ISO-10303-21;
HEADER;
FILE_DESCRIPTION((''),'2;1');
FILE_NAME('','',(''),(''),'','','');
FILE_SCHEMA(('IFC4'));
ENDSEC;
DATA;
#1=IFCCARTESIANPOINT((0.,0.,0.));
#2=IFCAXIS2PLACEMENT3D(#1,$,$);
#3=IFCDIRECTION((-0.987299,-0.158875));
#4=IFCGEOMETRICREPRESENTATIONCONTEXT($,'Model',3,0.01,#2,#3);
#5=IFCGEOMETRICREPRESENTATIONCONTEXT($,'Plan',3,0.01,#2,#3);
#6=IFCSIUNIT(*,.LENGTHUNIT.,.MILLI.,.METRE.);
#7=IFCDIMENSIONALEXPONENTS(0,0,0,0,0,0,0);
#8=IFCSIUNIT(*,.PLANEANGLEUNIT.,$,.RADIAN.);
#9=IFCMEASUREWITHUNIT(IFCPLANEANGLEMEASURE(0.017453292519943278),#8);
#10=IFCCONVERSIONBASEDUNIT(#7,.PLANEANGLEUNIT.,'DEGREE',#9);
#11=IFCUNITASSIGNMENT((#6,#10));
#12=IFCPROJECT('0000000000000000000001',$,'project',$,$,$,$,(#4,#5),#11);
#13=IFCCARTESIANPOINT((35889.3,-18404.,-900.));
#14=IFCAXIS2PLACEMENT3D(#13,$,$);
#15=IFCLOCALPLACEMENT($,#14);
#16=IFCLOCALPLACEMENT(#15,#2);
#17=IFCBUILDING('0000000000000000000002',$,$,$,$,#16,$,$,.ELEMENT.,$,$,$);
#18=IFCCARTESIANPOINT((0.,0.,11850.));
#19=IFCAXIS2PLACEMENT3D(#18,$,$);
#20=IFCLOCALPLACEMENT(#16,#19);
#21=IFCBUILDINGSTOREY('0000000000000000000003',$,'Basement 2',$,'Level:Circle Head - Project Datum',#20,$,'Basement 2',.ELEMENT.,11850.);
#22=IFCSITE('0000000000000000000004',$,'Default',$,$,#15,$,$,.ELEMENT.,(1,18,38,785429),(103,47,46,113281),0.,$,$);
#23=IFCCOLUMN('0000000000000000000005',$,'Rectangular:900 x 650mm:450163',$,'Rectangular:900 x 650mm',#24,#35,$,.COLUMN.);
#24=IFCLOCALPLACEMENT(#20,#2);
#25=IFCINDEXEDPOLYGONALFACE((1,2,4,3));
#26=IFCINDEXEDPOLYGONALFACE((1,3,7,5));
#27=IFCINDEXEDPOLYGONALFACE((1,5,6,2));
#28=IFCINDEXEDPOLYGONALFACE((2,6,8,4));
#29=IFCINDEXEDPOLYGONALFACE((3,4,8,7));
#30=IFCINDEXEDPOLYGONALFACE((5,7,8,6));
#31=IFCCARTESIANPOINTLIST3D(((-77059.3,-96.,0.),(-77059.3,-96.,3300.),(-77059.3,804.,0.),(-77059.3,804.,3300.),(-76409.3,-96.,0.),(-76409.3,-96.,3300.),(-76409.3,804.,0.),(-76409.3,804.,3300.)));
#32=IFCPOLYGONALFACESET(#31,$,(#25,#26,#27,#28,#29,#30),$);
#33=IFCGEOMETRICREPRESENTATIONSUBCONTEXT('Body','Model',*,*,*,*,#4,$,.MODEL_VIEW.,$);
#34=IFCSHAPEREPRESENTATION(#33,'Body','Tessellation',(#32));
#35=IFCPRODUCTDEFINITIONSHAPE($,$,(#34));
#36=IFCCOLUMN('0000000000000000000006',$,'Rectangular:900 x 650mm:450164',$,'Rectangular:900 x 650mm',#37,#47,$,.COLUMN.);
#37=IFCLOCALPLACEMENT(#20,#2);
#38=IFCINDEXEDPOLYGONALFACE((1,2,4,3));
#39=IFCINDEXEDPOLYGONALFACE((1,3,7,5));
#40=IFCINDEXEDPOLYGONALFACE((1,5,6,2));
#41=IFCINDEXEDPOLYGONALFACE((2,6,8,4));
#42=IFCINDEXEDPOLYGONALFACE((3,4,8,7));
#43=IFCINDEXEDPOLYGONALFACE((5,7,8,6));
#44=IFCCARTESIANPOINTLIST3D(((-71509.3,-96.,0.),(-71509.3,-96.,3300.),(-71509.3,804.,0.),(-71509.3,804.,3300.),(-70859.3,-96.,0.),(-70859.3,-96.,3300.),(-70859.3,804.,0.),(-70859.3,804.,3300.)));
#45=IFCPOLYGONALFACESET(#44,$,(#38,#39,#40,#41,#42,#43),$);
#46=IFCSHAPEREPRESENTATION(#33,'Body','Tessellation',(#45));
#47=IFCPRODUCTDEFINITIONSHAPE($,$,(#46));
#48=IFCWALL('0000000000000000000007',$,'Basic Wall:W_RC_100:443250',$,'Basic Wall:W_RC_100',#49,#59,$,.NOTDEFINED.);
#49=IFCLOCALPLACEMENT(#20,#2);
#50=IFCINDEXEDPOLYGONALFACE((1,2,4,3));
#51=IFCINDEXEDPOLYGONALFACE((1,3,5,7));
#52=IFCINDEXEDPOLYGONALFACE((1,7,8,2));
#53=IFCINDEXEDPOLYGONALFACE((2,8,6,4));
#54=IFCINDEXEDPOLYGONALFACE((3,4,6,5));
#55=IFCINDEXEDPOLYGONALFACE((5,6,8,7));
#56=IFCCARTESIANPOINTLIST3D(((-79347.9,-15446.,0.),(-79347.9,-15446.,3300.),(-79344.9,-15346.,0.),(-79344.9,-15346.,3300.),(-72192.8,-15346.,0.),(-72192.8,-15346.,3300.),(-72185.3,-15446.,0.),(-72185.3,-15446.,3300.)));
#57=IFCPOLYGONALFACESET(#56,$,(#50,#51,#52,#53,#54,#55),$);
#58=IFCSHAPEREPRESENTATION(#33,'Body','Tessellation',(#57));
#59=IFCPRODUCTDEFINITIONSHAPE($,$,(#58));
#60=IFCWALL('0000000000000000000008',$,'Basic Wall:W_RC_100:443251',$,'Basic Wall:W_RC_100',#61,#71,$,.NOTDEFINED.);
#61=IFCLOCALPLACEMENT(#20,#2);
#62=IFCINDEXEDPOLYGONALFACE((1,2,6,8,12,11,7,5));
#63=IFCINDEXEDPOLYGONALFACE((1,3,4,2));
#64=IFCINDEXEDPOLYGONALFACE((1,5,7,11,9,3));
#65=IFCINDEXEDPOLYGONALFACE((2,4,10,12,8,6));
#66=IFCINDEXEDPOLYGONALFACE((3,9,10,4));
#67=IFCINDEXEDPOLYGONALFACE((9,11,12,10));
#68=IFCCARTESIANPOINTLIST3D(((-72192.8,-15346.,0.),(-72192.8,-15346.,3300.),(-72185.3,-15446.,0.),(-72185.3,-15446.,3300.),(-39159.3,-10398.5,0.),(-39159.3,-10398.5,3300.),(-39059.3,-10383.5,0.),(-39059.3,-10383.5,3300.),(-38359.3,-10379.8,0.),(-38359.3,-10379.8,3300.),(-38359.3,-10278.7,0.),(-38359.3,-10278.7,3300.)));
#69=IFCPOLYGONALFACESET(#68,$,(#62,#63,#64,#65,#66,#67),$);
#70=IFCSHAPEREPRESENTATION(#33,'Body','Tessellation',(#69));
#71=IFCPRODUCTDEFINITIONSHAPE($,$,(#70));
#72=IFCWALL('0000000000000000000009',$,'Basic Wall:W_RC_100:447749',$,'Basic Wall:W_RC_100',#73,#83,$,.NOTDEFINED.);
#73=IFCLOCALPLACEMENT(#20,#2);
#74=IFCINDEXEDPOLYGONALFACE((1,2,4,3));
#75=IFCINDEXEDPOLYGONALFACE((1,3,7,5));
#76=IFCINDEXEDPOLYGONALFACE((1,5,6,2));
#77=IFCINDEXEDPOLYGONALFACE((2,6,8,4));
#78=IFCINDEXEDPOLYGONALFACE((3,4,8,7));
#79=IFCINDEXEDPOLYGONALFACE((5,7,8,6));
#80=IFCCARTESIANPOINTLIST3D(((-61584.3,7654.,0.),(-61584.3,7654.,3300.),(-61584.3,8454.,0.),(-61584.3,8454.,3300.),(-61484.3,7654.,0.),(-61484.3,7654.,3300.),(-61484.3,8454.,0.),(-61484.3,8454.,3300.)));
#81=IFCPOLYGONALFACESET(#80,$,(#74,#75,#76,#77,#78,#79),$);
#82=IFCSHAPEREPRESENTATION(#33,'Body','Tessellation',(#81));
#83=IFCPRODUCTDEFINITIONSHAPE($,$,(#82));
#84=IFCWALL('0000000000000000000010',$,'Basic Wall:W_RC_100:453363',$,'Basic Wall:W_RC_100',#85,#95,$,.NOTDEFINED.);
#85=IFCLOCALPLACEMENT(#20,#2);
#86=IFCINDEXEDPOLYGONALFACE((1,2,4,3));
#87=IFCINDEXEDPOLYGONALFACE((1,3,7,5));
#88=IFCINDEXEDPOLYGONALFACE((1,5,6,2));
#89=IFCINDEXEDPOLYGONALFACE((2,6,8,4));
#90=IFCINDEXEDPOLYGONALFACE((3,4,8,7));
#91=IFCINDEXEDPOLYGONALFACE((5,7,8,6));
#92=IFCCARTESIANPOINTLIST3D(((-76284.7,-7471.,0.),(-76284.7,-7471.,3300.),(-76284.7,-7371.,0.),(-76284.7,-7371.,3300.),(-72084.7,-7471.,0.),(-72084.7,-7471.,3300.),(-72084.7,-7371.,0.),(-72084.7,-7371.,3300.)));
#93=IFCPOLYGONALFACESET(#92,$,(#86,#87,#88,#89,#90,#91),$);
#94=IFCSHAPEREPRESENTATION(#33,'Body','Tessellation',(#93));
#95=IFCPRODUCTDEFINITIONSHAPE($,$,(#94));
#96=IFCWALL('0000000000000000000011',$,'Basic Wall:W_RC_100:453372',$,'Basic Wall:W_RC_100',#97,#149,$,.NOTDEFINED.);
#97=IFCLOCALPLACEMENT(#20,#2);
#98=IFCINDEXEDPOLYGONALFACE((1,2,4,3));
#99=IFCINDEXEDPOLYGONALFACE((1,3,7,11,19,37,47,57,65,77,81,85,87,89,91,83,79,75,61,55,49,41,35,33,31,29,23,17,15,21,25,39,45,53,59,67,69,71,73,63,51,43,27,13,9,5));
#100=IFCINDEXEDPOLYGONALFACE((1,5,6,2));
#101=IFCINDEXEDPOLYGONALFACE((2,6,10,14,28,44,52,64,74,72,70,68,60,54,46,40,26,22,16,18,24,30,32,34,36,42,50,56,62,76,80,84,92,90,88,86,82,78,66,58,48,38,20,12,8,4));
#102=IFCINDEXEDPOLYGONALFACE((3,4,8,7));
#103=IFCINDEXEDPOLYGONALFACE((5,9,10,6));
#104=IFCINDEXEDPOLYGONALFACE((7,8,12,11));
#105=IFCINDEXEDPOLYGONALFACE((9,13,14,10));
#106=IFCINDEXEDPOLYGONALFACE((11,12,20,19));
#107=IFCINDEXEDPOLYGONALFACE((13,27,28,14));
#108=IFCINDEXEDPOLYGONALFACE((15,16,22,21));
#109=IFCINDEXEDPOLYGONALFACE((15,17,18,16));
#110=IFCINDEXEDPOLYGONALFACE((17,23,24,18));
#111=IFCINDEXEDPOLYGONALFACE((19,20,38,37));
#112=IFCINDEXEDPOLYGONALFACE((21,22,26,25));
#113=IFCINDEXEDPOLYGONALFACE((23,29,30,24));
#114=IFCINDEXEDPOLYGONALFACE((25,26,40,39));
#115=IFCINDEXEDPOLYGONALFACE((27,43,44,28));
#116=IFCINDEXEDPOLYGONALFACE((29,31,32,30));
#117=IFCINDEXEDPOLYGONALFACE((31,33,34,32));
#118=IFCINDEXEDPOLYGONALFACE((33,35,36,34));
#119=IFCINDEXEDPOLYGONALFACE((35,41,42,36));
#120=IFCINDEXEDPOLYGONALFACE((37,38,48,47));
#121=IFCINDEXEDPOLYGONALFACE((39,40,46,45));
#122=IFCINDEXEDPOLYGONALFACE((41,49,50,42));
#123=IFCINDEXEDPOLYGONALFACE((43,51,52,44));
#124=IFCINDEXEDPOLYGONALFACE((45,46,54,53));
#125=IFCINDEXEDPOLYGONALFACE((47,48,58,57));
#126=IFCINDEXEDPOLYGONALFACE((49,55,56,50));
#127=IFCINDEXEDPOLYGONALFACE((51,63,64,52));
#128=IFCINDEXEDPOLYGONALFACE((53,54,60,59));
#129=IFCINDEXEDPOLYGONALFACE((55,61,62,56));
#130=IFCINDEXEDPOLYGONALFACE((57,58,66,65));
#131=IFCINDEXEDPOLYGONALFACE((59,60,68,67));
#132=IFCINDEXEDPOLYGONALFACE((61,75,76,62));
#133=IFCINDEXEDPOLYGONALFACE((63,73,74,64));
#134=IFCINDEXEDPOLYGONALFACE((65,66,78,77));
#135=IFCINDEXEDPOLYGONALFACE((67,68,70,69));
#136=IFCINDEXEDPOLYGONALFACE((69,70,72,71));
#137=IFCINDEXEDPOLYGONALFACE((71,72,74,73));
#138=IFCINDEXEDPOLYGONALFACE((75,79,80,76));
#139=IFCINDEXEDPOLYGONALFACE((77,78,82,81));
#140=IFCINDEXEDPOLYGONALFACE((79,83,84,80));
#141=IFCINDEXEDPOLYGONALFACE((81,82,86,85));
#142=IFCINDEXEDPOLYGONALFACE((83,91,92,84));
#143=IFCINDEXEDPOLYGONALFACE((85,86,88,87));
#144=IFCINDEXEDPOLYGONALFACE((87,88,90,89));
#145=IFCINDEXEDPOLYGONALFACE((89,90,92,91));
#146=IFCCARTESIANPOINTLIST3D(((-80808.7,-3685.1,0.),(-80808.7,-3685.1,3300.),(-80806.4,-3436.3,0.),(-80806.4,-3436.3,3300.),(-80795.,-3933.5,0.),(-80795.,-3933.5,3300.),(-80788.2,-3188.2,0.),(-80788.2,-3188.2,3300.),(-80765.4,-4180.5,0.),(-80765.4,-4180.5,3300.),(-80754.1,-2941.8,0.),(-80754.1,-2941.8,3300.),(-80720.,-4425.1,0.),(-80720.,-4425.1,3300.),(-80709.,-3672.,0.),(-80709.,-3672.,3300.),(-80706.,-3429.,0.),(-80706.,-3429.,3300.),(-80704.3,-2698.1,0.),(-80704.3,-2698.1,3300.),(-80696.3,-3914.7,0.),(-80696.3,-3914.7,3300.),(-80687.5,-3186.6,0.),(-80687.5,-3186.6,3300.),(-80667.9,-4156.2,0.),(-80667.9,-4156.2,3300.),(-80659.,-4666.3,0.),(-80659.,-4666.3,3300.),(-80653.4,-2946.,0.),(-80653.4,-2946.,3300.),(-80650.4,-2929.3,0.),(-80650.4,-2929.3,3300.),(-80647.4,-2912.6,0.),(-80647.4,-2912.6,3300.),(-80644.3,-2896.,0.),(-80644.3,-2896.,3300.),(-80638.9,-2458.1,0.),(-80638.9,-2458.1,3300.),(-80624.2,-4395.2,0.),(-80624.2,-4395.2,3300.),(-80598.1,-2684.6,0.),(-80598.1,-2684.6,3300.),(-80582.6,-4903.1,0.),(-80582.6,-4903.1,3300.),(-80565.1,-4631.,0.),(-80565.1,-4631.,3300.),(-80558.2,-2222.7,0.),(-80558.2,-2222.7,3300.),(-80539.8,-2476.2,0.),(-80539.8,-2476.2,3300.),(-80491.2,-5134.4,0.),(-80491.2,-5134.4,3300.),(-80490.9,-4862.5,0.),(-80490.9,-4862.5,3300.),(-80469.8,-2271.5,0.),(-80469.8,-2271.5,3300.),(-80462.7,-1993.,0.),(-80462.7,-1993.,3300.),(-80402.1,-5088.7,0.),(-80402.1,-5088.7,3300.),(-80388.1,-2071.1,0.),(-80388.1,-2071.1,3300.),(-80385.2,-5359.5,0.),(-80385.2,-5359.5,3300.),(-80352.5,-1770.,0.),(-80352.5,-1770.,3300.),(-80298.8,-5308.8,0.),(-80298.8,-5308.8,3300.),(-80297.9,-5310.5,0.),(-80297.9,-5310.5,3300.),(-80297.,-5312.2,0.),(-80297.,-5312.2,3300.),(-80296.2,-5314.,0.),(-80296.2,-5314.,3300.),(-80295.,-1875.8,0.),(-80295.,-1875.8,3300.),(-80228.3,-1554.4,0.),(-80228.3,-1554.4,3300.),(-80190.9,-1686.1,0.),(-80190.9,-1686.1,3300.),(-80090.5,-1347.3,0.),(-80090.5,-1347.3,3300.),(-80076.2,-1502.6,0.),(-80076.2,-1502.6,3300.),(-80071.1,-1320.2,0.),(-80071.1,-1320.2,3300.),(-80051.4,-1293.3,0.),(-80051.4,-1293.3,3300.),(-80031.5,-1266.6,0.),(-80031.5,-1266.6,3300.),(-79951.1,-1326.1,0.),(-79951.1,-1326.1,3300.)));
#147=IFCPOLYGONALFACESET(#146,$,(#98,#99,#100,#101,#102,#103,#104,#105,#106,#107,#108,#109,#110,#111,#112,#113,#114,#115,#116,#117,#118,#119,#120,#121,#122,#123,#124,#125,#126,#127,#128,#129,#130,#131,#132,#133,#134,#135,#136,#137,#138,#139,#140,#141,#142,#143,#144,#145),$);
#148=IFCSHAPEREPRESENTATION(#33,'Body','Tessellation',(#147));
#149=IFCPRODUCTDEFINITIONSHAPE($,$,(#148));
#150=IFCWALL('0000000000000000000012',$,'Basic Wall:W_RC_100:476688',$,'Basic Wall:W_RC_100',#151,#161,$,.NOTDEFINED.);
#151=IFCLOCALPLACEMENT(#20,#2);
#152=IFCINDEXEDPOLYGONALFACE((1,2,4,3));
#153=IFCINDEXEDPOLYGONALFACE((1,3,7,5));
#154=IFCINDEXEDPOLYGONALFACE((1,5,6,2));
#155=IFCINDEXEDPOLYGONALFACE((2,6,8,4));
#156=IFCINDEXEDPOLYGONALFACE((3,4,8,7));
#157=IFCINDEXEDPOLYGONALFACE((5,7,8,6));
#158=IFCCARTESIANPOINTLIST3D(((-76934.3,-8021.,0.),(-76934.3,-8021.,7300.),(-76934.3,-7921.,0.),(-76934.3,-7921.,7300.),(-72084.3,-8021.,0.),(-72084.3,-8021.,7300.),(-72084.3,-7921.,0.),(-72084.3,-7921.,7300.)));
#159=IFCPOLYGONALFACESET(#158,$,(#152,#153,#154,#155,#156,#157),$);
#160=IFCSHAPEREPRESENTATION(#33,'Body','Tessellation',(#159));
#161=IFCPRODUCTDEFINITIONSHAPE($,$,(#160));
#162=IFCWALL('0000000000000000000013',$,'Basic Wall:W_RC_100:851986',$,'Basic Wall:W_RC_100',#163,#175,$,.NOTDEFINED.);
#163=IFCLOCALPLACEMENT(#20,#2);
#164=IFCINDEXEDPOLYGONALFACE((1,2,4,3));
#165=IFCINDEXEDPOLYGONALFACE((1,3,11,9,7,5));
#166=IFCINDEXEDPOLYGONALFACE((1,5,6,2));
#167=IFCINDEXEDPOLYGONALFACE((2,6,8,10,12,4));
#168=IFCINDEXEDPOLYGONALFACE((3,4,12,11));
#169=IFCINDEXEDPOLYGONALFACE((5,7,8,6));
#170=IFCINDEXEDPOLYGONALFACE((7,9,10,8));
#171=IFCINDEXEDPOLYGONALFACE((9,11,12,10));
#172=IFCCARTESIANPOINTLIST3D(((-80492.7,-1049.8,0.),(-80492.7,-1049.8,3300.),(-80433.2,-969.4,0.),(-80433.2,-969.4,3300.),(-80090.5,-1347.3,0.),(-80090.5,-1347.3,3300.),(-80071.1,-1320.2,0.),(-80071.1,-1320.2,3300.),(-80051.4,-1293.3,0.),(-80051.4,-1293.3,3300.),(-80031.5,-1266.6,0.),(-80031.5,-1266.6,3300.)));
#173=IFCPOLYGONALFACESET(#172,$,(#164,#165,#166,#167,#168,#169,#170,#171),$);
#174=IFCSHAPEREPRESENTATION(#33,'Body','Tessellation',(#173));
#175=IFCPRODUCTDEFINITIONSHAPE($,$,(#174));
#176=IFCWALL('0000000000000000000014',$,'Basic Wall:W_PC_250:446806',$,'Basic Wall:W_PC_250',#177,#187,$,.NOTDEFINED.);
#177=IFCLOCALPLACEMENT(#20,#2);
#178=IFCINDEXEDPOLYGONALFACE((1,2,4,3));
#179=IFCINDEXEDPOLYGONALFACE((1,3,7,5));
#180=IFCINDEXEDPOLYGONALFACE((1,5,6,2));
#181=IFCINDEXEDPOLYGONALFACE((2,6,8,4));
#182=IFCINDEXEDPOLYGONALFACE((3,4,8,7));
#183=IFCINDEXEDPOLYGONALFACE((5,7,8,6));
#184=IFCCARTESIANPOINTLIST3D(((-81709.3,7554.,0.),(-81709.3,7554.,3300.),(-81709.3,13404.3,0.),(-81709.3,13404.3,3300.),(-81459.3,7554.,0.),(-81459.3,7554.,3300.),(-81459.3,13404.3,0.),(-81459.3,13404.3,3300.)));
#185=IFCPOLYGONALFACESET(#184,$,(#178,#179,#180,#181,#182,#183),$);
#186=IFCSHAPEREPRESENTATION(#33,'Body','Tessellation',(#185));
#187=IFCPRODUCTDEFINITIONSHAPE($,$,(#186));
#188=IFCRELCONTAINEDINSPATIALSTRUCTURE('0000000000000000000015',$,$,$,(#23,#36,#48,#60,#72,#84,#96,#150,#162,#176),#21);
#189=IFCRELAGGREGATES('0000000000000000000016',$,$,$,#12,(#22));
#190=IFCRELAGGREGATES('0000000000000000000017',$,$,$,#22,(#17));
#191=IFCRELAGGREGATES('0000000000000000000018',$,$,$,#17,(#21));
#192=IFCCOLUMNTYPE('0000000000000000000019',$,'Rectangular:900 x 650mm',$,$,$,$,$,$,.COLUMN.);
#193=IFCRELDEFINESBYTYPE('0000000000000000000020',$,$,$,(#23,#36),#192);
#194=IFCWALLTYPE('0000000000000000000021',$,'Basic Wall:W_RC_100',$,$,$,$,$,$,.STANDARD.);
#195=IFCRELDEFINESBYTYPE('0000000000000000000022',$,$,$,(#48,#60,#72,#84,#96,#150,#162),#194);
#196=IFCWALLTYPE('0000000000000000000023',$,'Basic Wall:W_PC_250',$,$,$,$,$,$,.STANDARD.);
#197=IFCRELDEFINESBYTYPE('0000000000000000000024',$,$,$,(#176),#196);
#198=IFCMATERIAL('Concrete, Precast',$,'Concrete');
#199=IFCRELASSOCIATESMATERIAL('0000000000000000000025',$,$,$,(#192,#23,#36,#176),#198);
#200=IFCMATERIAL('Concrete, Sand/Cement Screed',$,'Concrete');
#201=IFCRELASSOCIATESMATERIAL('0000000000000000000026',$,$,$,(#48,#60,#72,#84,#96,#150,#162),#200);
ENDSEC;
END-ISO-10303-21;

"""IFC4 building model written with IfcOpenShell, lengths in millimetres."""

from ifc_helpers import new_model, entity, si_unit, converted_unit, direction, frame, origin, place, context, subcontext, project, spatial, line, arc, indexed_curve, outline, extrude, source, transform, mapped, material, type_object, type_shapes, element, save


model = new_model("IFC4")

# Units and contexts
model_context = context("Model", 3, precision=0.01, world=origin(), true_north=direction((-0.987299, -0.158875)))
plan_context = context("Plan", 3, precision=0.01, world=origin(), true_north=direction((-0.987299, -0.158875)))
body_context = subcontext(model_context, "Body", "Model", "MODEL_VIEW")
ifc_project = project(units=[si_unit("LENGTHUNIT", "METRE", prefix="MILLI"), converted_unit("PLANEANGLEUNIT", "DEGREE", entity("IfcPlaneAngleMeasure", 0.017453292519943278), si_unit("PLANEANGLEUNIT", "RADIAN"), dimensions=[0, 0, 0, 0, 0, 0, 0])], contexts=[model_context, plan_context])

# Site, building, storey
site_placement = place(None, frame((35889.3, -18404.0, -900.0)))
site = spatial("IfcSite", under=ifc_project, at=site_placement, Name="Default", CompositionType="ELEMENT", RefLatitude=(1, 18, 38, 785429), RefLongitude=(103, 47, 46, 113281), RefElevation=0.0)
building_placement = place(site_placement, origin())
building = spatial("IfcBuilding", under=site, at=building_placement, CompositionType="ELEMENT")
storey_placement = place(building_placement, frame((0.0, 0.0, 11850.0)))
storey = spatial("IfcBuildingStorey", under=building, at=storey_placement, Name="Basement 2", ObjectType="Level:Circle Head - Project Datum", LongName="Basement 2", CompositionType="ELEMENT", Elevation=11850.0)

# Columns
ifc_material_1 = material(Name="Concrete, Precast", Category="Concrete")
column_type = type_object("IfcColumnType", Name="Rectangular:900 x 650mm", PredefinedType="COLUMN", material=ifc_material_1)
shared_shape_1 = source(origin(), body_context, "Body", "SweptSolid", [
    extrude(outline(indexed_curve([(-325.0, -450.0), (325.0, -450.0), (325.0, 450.0), (-325.0, 450.0), (-325.0, -450.0)], self_intersect=False)), frame((0.0, 0.0, 11850.0), z_axis=(0.0, 0.0, 1.0), x_axis=(-1.0, 0.0, 0.0)), (0.0, 0.0, 1.0), 3300.0),
])
type_shapes(column_type, [shared_shape_1])
for number, where, name in (
    (1, (-76734.3, 354.0, -11850.0), "Rectangular:900 x 650mm:450163"),
    (2, (-71184.3, 354.0, -11850.0), "Rectangular:900 x 650mm:450164"),
):
    element("IfcColumn", number, at=place(storey_placement, frame(where)), inside=storey, type_object=column_type, material=ifc_material_1, Name=name, ObjectType="Rectangular:900 x 650mm", PredefinedType="COLUMN", context=body_context, shape_type="MappedRepresentation", body=[
        mapped(shared_shape_1, transform((0.0, 0.0, 0.0), scale=1.0)),
    ])

# Walls
ifc_material_2 = material(Name="Concrete, Sand/Cement Screed", Category="Concrete")
wall_type_1 = type_object("IfcWallType", Name="Basic Wall:W_RC_100", PredefinedType="STANDARD")
wall_1_placement = place(storey_placement, frame((-72185.3, -15396.0, 0.0), z_axis=(0.0, 0.0, 1.0), x_axis=(-1.0, 0.0, 0.0)))
element("IfcWall", 3, at=wall_1_placement, inside=storey, type_object=wall_type_1, material=ifc_material_2, Name="Basic Wall:W_RC_100:443250", ObjectType="Basic Wall:W_RC_100", PredefinedType="NOTDEFINED", context=body_context, shape_type="SweptSolid", body=[
    extrude(outline(indexed_curve([(7159.5, -50.0), (7162.6, 50.0), (0.0, 50.0), (7.4, -50.0), (7159.5, -50.0)], self_intersect=False)), origin(), (0.0, 0.0, 1.0), 3300.0),
])
wall_2_placement = place(storey_placement, frame((-72192.7, -15396.5, 0.0), z_axis=(0.0, 0.0, 1.0), x_axis=(0.988969, 0.148119, 0.0)))
element("IfcWall", 4, at=wall_2_placement, inside=storey, type_object=wall_type_1, material=ifc_material_2, Name="Basic Wall:W_RC_100:443251", ObjectType="Basic Wall:W_RC_100", PredefinedType="NOTDEFINED", context=body_context, shape_type="SweptSolid", body=[
    extrude(outline(indexed_curve([(34203.3, -50.0), (34218.2, 50.0), (33510.4, 50.0), (33409.3, 50.0), (7.4, 50.0), (0.0, -50.0), (34203.3, -50.0)], self_intersect=False)), origin(), (0.0, 0.0, 1.0), 3300.0),
])
wall_3_placement = place(storey_placement, frame((-61534.3, 8454.0, 0.0), z_axis=(0.0, 0.0, 1.0), x_axis=(0.0, -1.0, 0.0)))
element("IfcWall", 5, at=wall_3_placement, inside=storey, type_object=wall_type_1, material=ifc_material_2, Name="Basic Wall:W_RC_100:447749", ObjectType="Basic Wall:W_RC_100", PredefinedType="NOTDEFINED", context=body_context, shape_type="SweptSolid", body=[
    extrude(outline(indexed_curve([(800.0, 50.0), (0.0, 50.0), (0.0, -50.0), (800.0, -50.0), (800.0, 50.0)], self_intersect=False)), origin(), (0.0, 0.0, 1.0), 3300.0),
])
wall_4_placement = place(storey_placement, frame((-76284.7, -7421.0, 0.0)))
element("IfcWall", 6, at=wall_4_placement, inside=storey, type_object=wall_type_1, material=ifc_material_2, Name="Basic Wall:W_RC_100:453363", ObjectType="Basic Wall:W_RC_100", PredefinedType="NOTDEFINED", context=body_context, shape_type="SweptSolid", body=[
    extrude(outline(indexed_curve([(4200.0, 50.0), (0.0, 50.0), (0.0, -50.0), (4200.0, -50.0), (4200.0, 50.0)], self_intersect=False)), origin(), (0.0, 0.0, 1.0), 3300.0),
])
wall_5_placement = place(storey_placement, frame((-79991.0, -1296.0, 0.0)))
element("IfcWall", 7, at=wall_5_placement, inside=storey, type_object=wall_type_1, material=ifc_material_2, Name="Basic Wall:W_RC_100:453372", ObjectType="Basic Wall:W_RC_100", PredefinedType="NOTDEFINED", context=body_context, shape_type="SweptSolid", body=[
    extrude(outline(indexed_curve([(-305.1, -4017.9), (-306.5, -4015.3), (-307.8, -4012.7), (-676.9, -2860.1), (-662.3, -1649.9), (-657.9, -1624.9), (-653.2, -1599.9), (-397.0, -775.1), (40.0, -30.1), (-40.4, 29.4), (-70.2, -10.7), (-99.5, -51.3), (-808.3, -2016.1), (-394.2, -4063.5)], segments=[arc(1, 2, 3), arc(3, 4, 5), arc(5, 6, 7), arc(7, 8, 9), line(9, 10), arc(10, 11, 12), arc(12, 13, 14), line(14, 1)], self_intersect=False)), origin(), (0.0, 0.0, 1.0), 3300.0),
])
wall_6_placement = place(storey_placement, frame((-72084.3, -7971.0, 0.0), z_axis=(0.0, 0.0, 1.0), x_axis=(-1.0, 0.0, 0.0)))
element("IfcWall", 8, at=wall_6_placement, inside=storey, type_object=wall_type_1, material=ifc_material_2, Name="Basic Wall:W_RC_100:476688", ObjectType="Basic Wall:W_RC_100", PredefinedType="NOTDEFINED", context=body_context, shape_type="SweptSolid", body=[
    extrude(outline(indexed_curve([(4850.0, 50.0), (0.0, 50.0), (0.0, -50.0), (4850.0, -50.0), (4850.0, 50.0)], self_intersect=False)), origin(), (0.0, 0.0, 1.0), 7300.0),
])
wall_7_placement = place(storey_placement, frame((-80463.0, -1009.6, 0.0), z_axis=(0.0, 0.0, 1.0), x_axis=(0.803918, -0.59474, 0.0)))
element("IfcWall", 9, at=wall_7_placement, inside=storey, type_object=wall_type_1, material=ifc_material_2, Name="Basic Wall:W_RC_100:851986", ObjectType="Basic Wall:W_RC_100", PredefinedType="NOTDEFINED", context=body_context, shape_type="SweptSolid", body=[
    extrude(outline(indexed_curve([(500.3, -50.0), (499.7, 0.0), (499.8, 50.0), (0.0, 50.0), (0.0, -50.0)], segments=[arc(1, 2, 3), line(3, 4, 5, 1)], self_intersect=False)), origin(), (0.0, 0.0, 1.0), 3300.0),
])
wall_type_2 = type_object("IfcWallType", Name="Basic Wall:W_PC_250", PredefinedType="STANDARD")
wall_8_placement = place(storey_placement, frame((-81584.3, 7554.0, 0.0), z_axis=(0.0, 0.0, 1.0), x_axis=(0.0, 1.0, 0.0)))
element("IfcWall", 10, at=wall_8_placement, inside=storey, type_object=wall_type_2, material=ifc_material_1, Name="Basic Wall:W_PC_250:446806", ObjectType="Basic Wall:W_PC_250", PredefinedType="NOTDEFINED", context=body_context, shape_type="SweptSolid", body=[
    extrude(outline(indexed_curve([(5850.3, 125.0), (0.0, 125.0), (0.0, -125.0), (5850.3, -125.0), (5850.3, 125.0)], self_intersect=False)), origin(), (0.0, 0.0, 1.0), 3300.0),
])

save(model, "model.ifc")
